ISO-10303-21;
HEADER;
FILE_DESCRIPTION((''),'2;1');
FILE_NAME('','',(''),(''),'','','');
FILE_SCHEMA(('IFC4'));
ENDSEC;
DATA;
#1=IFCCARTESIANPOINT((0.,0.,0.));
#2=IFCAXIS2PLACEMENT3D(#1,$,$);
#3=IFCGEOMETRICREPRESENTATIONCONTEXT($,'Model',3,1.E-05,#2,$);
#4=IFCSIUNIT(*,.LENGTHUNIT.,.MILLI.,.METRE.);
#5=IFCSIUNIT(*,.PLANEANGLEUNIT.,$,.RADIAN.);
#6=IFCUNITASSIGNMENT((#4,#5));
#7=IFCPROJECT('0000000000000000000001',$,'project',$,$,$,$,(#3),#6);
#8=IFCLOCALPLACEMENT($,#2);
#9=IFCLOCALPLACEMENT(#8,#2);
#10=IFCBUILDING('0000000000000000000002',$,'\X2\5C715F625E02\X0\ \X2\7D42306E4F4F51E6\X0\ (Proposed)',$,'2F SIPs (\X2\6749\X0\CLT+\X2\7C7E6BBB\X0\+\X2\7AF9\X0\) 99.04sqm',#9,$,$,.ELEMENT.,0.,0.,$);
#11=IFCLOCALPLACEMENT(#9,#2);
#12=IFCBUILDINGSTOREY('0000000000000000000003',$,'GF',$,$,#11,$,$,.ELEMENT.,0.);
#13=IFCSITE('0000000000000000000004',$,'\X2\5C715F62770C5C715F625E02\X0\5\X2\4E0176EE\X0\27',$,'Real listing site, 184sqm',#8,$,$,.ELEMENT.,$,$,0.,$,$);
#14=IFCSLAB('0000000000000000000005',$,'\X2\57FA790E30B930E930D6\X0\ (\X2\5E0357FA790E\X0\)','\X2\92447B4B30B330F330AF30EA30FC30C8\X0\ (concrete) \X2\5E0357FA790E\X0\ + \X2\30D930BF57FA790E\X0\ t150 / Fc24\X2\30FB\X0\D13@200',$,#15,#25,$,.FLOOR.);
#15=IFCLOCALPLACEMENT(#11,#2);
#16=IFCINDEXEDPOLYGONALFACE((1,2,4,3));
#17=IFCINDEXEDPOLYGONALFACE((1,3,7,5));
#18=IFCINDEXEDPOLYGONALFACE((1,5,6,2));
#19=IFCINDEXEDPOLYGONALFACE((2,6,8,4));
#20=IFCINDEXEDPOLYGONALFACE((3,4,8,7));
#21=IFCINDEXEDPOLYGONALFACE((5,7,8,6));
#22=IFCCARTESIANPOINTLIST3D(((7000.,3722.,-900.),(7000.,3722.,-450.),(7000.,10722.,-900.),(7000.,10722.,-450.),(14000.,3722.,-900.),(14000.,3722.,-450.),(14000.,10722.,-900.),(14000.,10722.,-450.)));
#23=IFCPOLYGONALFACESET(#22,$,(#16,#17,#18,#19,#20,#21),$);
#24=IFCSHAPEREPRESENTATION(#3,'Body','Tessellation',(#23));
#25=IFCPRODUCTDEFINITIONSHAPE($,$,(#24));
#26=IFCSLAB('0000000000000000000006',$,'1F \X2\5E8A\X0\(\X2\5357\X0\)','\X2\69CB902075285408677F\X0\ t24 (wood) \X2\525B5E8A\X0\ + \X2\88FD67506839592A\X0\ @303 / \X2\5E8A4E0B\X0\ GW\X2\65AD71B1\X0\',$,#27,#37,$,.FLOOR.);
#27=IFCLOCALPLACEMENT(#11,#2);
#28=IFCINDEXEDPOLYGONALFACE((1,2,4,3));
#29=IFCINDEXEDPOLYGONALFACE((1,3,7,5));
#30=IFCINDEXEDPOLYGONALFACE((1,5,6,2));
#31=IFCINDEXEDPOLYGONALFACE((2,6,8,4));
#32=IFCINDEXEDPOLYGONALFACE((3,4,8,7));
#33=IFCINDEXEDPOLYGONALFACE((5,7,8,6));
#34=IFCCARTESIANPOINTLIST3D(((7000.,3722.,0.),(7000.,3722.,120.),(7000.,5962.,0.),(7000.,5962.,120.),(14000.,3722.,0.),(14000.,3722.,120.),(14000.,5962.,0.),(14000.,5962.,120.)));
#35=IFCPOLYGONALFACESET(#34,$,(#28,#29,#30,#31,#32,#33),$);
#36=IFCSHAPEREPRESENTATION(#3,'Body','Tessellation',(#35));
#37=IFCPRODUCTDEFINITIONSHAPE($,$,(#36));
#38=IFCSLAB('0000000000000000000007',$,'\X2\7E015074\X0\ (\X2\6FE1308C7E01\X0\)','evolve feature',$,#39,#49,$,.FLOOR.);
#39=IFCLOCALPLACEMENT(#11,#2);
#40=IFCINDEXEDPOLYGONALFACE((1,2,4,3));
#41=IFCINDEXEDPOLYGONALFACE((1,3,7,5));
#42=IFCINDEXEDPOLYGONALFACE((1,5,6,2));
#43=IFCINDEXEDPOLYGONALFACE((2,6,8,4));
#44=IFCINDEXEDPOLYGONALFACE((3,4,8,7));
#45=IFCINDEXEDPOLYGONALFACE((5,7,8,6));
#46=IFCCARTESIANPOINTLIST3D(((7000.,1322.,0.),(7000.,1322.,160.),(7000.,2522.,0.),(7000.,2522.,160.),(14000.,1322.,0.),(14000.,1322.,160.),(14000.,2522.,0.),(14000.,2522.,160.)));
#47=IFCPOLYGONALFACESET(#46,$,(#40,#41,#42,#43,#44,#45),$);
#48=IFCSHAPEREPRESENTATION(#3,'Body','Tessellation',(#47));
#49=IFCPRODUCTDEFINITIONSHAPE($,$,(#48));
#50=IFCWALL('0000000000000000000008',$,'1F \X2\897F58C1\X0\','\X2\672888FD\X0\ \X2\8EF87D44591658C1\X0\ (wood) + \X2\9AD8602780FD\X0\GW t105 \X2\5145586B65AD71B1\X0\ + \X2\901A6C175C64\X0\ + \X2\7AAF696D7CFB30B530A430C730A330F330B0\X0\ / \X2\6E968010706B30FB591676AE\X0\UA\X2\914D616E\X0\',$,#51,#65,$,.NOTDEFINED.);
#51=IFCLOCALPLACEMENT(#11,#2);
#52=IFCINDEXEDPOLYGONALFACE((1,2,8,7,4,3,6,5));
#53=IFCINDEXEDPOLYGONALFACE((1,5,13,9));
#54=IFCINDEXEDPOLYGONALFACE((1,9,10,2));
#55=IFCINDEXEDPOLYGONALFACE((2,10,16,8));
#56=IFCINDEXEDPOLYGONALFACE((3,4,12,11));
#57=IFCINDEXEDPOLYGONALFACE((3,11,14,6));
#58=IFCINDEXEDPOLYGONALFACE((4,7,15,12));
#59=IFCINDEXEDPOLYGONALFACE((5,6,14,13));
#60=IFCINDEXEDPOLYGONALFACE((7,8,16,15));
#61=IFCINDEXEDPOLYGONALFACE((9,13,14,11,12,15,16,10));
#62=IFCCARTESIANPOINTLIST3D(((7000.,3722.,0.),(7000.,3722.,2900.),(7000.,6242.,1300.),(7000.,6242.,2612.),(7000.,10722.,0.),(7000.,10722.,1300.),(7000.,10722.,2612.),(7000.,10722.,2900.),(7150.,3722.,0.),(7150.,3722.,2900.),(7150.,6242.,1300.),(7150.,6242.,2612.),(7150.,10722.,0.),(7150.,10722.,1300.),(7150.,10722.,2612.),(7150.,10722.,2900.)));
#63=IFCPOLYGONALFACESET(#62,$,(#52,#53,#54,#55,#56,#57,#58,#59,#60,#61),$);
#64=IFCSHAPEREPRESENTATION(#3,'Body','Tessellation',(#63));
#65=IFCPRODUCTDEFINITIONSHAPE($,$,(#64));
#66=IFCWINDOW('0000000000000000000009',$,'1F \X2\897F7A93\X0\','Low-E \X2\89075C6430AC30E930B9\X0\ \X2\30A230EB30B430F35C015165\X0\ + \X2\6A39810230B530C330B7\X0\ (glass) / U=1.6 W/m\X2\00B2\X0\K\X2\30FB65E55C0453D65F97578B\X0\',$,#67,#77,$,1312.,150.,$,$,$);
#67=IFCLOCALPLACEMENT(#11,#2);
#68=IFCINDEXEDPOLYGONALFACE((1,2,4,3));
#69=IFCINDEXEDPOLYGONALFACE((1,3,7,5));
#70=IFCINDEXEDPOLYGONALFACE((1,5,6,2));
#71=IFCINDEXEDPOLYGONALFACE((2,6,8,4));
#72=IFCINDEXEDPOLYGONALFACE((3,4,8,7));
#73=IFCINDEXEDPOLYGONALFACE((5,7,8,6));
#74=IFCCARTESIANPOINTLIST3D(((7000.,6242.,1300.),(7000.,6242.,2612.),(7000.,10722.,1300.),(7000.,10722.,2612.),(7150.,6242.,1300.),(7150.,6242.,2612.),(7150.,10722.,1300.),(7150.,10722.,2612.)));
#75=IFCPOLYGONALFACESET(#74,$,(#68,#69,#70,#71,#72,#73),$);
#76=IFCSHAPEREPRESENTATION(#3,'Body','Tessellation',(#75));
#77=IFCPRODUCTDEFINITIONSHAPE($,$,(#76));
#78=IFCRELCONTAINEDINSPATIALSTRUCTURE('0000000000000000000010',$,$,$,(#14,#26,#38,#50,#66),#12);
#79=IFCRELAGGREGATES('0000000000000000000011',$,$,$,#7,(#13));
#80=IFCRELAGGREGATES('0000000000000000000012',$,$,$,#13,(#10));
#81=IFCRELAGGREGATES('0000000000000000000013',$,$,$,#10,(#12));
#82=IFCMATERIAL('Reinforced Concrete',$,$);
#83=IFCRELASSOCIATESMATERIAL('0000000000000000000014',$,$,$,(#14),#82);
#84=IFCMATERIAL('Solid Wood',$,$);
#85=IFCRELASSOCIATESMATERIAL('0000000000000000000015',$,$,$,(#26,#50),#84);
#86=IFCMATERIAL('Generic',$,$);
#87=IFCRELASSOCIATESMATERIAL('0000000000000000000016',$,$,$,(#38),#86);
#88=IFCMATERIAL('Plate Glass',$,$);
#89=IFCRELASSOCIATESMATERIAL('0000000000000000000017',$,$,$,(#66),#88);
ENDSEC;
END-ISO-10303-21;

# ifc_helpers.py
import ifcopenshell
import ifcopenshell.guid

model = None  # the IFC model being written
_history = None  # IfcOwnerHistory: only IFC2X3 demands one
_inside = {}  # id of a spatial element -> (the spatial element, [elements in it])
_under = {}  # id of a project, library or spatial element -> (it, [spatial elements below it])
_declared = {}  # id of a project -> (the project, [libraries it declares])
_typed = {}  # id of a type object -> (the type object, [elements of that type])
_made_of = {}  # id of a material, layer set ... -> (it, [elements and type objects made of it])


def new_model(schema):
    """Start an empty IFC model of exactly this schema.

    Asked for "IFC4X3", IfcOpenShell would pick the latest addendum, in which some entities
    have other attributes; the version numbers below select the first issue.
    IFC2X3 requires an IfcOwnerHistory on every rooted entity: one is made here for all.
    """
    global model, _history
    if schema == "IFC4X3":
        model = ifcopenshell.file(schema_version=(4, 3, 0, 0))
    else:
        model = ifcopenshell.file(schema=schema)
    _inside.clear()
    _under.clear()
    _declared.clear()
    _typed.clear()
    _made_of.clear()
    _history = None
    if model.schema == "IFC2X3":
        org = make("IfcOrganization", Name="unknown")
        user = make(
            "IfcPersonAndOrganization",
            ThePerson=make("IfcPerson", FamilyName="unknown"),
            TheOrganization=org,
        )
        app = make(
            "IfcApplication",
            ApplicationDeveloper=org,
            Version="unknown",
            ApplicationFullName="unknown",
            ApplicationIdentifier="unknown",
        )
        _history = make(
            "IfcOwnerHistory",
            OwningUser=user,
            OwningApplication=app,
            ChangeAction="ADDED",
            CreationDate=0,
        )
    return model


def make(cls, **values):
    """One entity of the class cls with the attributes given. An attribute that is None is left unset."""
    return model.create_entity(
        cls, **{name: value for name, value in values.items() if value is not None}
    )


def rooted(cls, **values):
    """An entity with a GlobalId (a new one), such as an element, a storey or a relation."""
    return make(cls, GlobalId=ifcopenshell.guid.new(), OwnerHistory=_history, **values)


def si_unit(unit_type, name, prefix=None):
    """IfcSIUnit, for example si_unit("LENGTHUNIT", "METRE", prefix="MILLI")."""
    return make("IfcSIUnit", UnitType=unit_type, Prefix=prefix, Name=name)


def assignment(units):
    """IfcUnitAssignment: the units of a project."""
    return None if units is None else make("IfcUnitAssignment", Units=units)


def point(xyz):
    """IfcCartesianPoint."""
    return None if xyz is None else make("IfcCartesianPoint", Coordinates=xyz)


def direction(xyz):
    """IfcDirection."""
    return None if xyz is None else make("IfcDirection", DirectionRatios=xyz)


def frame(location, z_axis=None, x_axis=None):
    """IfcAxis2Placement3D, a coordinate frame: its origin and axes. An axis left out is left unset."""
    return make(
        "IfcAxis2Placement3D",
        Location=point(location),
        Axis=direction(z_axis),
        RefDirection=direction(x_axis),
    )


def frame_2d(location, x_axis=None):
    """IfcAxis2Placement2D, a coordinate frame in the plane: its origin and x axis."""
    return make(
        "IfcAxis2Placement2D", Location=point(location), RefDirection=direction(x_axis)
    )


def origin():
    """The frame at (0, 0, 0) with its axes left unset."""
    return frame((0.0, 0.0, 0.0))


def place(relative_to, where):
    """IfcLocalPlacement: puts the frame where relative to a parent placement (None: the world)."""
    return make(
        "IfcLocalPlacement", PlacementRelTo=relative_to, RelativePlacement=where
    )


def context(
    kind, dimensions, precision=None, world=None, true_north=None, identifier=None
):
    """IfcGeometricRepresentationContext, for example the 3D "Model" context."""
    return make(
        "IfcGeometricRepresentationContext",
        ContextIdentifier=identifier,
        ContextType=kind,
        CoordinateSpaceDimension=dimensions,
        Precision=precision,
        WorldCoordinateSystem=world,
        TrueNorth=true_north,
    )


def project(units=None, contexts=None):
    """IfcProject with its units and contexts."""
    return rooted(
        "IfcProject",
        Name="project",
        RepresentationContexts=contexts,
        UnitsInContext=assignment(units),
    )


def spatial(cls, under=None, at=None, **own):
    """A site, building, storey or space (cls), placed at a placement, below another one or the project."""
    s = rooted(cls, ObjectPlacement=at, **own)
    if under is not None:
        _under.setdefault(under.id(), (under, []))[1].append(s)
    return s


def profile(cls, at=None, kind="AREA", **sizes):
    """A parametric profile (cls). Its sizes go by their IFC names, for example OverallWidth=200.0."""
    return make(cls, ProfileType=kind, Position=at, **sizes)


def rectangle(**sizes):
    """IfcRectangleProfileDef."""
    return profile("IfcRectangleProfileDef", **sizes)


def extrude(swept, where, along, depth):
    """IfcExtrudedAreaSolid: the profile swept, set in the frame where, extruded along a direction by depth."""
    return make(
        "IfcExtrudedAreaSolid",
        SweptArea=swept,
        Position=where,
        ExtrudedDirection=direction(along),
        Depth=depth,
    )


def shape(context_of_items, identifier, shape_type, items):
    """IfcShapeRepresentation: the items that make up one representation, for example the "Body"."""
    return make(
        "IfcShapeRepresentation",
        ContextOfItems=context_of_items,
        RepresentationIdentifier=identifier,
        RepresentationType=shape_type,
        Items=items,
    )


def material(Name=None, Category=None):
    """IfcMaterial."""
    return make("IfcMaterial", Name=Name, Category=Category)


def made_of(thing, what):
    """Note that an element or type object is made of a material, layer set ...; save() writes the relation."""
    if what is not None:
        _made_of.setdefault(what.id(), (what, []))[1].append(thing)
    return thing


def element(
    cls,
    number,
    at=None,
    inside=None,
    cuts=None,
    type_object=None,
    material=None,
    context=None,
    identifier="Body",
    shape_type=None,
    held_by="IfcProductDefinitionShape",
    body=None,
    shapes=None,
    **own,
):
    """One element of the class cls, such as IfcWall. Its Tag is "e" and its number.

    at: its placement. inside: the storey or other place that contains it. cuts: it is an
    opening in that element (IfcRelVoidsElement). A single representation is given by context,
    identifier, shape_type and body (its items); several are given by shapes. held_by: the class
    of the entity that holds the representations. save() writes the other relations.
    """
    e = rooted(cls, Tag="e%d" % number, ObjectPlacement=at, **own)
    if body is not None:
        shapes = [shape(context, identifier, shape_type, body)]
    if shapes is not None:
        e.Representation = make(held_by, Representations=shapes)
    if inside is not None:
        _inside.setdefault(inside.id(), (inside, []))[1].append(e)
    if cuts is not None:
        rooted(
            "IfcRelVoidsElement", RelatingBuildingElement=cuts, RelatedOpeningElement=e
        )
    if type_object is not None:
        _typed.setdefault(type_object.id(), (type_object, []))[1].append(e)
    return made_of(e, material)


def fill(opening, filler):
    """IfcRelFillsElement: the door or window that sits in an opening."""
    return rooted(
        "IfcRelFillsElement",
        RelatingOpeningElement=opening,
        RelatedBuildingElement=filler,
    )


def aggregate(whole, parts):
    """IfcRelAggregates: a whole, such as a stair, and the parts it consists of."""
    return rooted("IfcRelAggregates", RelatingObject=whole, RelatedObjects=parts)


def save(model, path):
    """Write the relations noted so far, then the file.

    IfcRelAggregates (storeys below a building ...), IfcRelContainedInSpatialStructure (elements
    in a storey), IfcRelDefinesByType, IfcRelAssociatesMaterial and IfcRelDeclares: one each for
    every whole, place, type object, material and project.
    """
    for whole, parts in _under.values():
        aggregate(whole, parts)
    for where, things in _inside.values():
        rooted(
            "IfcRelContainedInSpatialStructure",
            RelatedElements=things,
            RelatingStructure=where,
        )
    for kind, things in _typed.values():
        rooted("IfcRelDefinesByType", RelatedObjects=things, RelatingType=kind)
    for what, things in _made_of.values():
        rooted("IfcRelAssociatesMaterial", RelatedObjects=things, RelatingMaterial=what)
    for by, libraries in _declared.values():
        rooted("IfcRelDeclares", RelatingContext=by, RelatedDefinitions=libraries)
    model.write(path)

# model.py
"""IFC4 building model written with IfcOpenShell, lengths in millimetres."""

from ifc_helpers import new_model, si_unit, frame, frame_2d, origin, place, context, project, spatial, rectangle, extrude, material, element, fill, save


model = new_model("IFC4")

# Units and contexts
model_context = context("Model", 3, precision=1e-05, world=origin())
ifc_project = project(units=[si_unit("LENGTHUNIT", "METRE", prefix="MILLI"), si_unit("PLANEANGLEUNIT", "RADIAN")], contexts=[model_context])

# Site, building, storey
site_placement = place(None, origin())
site = spatial("IfcSite", under=ifc_project, at=site_placement, Name="山形県山形市5丁目27", ObjectType="Real listing site, 184sqm", CompositionType="ELEMENT", RefElevation=0.0)
building_placement = place(site_placement, origin())
building = spatial("IfcBuilding", under=site, at=building_placement, Name="山形市 終の住処 (Proposed)", ObjectType="2F SIPs (杉CLT+籾殻+竹) 99.04sqm", CompositionType="ELEMENT", ElevationOfRefHeight=0.0, ElevationOfTerrain=0.0)
storey_placement = place(building_placement, origin())
storey = spatial("IfcBuildingStorey", under=building, at=storey_placement, Name="GF", CompositionType="ELEMENT", Elevation=0.0)

# Slabs
ifc_material_1 = material(Name="Reinforced Concrete")
slab_1_placement = place(storey_placement, frame((3500.0, 1861.0, -450.0)))
element("IfcSlab", 1, at=slab_1_placement, inside=storey, material=ifc_material_1, Name="基礎スラブ (布基礎)", Description="鉄筋コンクリート (concrete) 布基礎 + ベタ基礎 t150 / Fc24・D13@200", PredefinedType="FLOOR", context=model_context, shape_type="SweptSolid", body=[
    extrude(rectangle(XDim=7000.0, YDim=7000.0, at=frame_2d((3500.0, 3500.0))), frame((3500.0, 1861.0, -450.0)), (0.0, 0.0, 1.0), 450.0),
])
ifc_material_2 = material(Name="Solid Wood")
slab_2_placement = place(storey_placement, frame((3500.0, 1861.0, 0.0)))
element("IfcSlab", 2, at=slab_2_placement, inside=storey, material=ifc_material_2, Name="1F 床(南)", Description="構造用合板 t24 (wood) 剛床 + 製材根太 @303 / 床下 GW断熱", PredefinedType="FLOOR", context=model_context, shape_type="SweptSolid", body=[
    extrude(rectangle(XDim=7000.0, YDim=2240.0, at=frame_2d((3500.0, 1120.0))), frame((3500.0, 1861.0, 0.0)), (0.0, 0.0, 1.0), 120.0),
])
ifc_material_3 = material(Name="Generic")
slab_3_placement = place(storey_placement, frame((3500.0, 661.0, 0.0)))
element("IfcSlab", 3, at=slab_3_placement, inside=storey, material=ifc_material_3, Name="縁側 (濡れ縁)", Description="evolve feature", PredefinedType="FLOOR", context=model_context, shape_type="SweptSolid", body=[
    extrude(rectangle(XDim=7000.0, YDim=1200.0, at=frame_2d((3500.0, 600.0))), frame((3500.0, 661.0, 0.0)), (0.0, 0.0, 1.0), 160.0),
])

# Shared definitions
ifc_material_4 = material(Name="Plate Glass")

# Wall, opening, window
wall_1_placement = place(storey_placement, frame((3500.0, 1861.0, 0.0)))
wall_1 = element("IfcWall", 4, at=wall_1_placement, inside=storey, material=ifc_material_2, Name="1F 西壁", Description="木製 軸組外壁 (wood) + 高性能GW t105 充填断熱 + 通気層 + 窯業系サイディング / 準耐火・外皮UA配慮", PredefinedType="NOTDEFINED", context=model_context, shape_type="SweptSolid", body=[
    extrude(rectangle(XDim=150.0, YDim=7000.0, at=frame_2d((75.0, 3500.0))), frame((3500.0, 1861.0, 0.0)), (0.0, 0.0, 1.0), 2900.0),
])
opening_1_placement = place(storey_placement, frame((3500.0, 3121.0, 650.0)))
opening_1 = element("IfcOpeningElement", 5, at=opening_1_placement, cuts=wall_1, PredefinedType="NOTDEFINED", context=model_context, shape_type="SweptSolid", body=[
    extrude(rectangle(XDim=150.0, YDim=4480.0, at=frame_2d((75.0, 2240.0))), frame((3500.0, 3121.0, 650.0)), (0.0, 0.0, 1.0), 1312.0),
])
window_1_placement = place(storey_placement, frame((3500.0, 3121.0, 650.0)))
window_1 = element("IfcWindow", 6, at=window_1_placement, inside=storey, material=ifc_material_4, Name="1F 西窓", Description="Low-E 複層ガラス アルゴン封入 + 樹脂サッシ (glass) / U=1.6 W/m²K・日射取得型", OverallHeight=1312.0, OverallWidth=150.0, context=model_context, shape_type="SweptSolid", body=[
    extrude(rectangle(XDim=150.0, YDim=4480.0, at=frame_2d((75.0, 2240.0))), frame((3500.0, 3121.0, 650.0)), (0.0, 0.0, 1.0), 1312.0),
])
fill(opening_1, window_1)

save(model, "model.ifc")
